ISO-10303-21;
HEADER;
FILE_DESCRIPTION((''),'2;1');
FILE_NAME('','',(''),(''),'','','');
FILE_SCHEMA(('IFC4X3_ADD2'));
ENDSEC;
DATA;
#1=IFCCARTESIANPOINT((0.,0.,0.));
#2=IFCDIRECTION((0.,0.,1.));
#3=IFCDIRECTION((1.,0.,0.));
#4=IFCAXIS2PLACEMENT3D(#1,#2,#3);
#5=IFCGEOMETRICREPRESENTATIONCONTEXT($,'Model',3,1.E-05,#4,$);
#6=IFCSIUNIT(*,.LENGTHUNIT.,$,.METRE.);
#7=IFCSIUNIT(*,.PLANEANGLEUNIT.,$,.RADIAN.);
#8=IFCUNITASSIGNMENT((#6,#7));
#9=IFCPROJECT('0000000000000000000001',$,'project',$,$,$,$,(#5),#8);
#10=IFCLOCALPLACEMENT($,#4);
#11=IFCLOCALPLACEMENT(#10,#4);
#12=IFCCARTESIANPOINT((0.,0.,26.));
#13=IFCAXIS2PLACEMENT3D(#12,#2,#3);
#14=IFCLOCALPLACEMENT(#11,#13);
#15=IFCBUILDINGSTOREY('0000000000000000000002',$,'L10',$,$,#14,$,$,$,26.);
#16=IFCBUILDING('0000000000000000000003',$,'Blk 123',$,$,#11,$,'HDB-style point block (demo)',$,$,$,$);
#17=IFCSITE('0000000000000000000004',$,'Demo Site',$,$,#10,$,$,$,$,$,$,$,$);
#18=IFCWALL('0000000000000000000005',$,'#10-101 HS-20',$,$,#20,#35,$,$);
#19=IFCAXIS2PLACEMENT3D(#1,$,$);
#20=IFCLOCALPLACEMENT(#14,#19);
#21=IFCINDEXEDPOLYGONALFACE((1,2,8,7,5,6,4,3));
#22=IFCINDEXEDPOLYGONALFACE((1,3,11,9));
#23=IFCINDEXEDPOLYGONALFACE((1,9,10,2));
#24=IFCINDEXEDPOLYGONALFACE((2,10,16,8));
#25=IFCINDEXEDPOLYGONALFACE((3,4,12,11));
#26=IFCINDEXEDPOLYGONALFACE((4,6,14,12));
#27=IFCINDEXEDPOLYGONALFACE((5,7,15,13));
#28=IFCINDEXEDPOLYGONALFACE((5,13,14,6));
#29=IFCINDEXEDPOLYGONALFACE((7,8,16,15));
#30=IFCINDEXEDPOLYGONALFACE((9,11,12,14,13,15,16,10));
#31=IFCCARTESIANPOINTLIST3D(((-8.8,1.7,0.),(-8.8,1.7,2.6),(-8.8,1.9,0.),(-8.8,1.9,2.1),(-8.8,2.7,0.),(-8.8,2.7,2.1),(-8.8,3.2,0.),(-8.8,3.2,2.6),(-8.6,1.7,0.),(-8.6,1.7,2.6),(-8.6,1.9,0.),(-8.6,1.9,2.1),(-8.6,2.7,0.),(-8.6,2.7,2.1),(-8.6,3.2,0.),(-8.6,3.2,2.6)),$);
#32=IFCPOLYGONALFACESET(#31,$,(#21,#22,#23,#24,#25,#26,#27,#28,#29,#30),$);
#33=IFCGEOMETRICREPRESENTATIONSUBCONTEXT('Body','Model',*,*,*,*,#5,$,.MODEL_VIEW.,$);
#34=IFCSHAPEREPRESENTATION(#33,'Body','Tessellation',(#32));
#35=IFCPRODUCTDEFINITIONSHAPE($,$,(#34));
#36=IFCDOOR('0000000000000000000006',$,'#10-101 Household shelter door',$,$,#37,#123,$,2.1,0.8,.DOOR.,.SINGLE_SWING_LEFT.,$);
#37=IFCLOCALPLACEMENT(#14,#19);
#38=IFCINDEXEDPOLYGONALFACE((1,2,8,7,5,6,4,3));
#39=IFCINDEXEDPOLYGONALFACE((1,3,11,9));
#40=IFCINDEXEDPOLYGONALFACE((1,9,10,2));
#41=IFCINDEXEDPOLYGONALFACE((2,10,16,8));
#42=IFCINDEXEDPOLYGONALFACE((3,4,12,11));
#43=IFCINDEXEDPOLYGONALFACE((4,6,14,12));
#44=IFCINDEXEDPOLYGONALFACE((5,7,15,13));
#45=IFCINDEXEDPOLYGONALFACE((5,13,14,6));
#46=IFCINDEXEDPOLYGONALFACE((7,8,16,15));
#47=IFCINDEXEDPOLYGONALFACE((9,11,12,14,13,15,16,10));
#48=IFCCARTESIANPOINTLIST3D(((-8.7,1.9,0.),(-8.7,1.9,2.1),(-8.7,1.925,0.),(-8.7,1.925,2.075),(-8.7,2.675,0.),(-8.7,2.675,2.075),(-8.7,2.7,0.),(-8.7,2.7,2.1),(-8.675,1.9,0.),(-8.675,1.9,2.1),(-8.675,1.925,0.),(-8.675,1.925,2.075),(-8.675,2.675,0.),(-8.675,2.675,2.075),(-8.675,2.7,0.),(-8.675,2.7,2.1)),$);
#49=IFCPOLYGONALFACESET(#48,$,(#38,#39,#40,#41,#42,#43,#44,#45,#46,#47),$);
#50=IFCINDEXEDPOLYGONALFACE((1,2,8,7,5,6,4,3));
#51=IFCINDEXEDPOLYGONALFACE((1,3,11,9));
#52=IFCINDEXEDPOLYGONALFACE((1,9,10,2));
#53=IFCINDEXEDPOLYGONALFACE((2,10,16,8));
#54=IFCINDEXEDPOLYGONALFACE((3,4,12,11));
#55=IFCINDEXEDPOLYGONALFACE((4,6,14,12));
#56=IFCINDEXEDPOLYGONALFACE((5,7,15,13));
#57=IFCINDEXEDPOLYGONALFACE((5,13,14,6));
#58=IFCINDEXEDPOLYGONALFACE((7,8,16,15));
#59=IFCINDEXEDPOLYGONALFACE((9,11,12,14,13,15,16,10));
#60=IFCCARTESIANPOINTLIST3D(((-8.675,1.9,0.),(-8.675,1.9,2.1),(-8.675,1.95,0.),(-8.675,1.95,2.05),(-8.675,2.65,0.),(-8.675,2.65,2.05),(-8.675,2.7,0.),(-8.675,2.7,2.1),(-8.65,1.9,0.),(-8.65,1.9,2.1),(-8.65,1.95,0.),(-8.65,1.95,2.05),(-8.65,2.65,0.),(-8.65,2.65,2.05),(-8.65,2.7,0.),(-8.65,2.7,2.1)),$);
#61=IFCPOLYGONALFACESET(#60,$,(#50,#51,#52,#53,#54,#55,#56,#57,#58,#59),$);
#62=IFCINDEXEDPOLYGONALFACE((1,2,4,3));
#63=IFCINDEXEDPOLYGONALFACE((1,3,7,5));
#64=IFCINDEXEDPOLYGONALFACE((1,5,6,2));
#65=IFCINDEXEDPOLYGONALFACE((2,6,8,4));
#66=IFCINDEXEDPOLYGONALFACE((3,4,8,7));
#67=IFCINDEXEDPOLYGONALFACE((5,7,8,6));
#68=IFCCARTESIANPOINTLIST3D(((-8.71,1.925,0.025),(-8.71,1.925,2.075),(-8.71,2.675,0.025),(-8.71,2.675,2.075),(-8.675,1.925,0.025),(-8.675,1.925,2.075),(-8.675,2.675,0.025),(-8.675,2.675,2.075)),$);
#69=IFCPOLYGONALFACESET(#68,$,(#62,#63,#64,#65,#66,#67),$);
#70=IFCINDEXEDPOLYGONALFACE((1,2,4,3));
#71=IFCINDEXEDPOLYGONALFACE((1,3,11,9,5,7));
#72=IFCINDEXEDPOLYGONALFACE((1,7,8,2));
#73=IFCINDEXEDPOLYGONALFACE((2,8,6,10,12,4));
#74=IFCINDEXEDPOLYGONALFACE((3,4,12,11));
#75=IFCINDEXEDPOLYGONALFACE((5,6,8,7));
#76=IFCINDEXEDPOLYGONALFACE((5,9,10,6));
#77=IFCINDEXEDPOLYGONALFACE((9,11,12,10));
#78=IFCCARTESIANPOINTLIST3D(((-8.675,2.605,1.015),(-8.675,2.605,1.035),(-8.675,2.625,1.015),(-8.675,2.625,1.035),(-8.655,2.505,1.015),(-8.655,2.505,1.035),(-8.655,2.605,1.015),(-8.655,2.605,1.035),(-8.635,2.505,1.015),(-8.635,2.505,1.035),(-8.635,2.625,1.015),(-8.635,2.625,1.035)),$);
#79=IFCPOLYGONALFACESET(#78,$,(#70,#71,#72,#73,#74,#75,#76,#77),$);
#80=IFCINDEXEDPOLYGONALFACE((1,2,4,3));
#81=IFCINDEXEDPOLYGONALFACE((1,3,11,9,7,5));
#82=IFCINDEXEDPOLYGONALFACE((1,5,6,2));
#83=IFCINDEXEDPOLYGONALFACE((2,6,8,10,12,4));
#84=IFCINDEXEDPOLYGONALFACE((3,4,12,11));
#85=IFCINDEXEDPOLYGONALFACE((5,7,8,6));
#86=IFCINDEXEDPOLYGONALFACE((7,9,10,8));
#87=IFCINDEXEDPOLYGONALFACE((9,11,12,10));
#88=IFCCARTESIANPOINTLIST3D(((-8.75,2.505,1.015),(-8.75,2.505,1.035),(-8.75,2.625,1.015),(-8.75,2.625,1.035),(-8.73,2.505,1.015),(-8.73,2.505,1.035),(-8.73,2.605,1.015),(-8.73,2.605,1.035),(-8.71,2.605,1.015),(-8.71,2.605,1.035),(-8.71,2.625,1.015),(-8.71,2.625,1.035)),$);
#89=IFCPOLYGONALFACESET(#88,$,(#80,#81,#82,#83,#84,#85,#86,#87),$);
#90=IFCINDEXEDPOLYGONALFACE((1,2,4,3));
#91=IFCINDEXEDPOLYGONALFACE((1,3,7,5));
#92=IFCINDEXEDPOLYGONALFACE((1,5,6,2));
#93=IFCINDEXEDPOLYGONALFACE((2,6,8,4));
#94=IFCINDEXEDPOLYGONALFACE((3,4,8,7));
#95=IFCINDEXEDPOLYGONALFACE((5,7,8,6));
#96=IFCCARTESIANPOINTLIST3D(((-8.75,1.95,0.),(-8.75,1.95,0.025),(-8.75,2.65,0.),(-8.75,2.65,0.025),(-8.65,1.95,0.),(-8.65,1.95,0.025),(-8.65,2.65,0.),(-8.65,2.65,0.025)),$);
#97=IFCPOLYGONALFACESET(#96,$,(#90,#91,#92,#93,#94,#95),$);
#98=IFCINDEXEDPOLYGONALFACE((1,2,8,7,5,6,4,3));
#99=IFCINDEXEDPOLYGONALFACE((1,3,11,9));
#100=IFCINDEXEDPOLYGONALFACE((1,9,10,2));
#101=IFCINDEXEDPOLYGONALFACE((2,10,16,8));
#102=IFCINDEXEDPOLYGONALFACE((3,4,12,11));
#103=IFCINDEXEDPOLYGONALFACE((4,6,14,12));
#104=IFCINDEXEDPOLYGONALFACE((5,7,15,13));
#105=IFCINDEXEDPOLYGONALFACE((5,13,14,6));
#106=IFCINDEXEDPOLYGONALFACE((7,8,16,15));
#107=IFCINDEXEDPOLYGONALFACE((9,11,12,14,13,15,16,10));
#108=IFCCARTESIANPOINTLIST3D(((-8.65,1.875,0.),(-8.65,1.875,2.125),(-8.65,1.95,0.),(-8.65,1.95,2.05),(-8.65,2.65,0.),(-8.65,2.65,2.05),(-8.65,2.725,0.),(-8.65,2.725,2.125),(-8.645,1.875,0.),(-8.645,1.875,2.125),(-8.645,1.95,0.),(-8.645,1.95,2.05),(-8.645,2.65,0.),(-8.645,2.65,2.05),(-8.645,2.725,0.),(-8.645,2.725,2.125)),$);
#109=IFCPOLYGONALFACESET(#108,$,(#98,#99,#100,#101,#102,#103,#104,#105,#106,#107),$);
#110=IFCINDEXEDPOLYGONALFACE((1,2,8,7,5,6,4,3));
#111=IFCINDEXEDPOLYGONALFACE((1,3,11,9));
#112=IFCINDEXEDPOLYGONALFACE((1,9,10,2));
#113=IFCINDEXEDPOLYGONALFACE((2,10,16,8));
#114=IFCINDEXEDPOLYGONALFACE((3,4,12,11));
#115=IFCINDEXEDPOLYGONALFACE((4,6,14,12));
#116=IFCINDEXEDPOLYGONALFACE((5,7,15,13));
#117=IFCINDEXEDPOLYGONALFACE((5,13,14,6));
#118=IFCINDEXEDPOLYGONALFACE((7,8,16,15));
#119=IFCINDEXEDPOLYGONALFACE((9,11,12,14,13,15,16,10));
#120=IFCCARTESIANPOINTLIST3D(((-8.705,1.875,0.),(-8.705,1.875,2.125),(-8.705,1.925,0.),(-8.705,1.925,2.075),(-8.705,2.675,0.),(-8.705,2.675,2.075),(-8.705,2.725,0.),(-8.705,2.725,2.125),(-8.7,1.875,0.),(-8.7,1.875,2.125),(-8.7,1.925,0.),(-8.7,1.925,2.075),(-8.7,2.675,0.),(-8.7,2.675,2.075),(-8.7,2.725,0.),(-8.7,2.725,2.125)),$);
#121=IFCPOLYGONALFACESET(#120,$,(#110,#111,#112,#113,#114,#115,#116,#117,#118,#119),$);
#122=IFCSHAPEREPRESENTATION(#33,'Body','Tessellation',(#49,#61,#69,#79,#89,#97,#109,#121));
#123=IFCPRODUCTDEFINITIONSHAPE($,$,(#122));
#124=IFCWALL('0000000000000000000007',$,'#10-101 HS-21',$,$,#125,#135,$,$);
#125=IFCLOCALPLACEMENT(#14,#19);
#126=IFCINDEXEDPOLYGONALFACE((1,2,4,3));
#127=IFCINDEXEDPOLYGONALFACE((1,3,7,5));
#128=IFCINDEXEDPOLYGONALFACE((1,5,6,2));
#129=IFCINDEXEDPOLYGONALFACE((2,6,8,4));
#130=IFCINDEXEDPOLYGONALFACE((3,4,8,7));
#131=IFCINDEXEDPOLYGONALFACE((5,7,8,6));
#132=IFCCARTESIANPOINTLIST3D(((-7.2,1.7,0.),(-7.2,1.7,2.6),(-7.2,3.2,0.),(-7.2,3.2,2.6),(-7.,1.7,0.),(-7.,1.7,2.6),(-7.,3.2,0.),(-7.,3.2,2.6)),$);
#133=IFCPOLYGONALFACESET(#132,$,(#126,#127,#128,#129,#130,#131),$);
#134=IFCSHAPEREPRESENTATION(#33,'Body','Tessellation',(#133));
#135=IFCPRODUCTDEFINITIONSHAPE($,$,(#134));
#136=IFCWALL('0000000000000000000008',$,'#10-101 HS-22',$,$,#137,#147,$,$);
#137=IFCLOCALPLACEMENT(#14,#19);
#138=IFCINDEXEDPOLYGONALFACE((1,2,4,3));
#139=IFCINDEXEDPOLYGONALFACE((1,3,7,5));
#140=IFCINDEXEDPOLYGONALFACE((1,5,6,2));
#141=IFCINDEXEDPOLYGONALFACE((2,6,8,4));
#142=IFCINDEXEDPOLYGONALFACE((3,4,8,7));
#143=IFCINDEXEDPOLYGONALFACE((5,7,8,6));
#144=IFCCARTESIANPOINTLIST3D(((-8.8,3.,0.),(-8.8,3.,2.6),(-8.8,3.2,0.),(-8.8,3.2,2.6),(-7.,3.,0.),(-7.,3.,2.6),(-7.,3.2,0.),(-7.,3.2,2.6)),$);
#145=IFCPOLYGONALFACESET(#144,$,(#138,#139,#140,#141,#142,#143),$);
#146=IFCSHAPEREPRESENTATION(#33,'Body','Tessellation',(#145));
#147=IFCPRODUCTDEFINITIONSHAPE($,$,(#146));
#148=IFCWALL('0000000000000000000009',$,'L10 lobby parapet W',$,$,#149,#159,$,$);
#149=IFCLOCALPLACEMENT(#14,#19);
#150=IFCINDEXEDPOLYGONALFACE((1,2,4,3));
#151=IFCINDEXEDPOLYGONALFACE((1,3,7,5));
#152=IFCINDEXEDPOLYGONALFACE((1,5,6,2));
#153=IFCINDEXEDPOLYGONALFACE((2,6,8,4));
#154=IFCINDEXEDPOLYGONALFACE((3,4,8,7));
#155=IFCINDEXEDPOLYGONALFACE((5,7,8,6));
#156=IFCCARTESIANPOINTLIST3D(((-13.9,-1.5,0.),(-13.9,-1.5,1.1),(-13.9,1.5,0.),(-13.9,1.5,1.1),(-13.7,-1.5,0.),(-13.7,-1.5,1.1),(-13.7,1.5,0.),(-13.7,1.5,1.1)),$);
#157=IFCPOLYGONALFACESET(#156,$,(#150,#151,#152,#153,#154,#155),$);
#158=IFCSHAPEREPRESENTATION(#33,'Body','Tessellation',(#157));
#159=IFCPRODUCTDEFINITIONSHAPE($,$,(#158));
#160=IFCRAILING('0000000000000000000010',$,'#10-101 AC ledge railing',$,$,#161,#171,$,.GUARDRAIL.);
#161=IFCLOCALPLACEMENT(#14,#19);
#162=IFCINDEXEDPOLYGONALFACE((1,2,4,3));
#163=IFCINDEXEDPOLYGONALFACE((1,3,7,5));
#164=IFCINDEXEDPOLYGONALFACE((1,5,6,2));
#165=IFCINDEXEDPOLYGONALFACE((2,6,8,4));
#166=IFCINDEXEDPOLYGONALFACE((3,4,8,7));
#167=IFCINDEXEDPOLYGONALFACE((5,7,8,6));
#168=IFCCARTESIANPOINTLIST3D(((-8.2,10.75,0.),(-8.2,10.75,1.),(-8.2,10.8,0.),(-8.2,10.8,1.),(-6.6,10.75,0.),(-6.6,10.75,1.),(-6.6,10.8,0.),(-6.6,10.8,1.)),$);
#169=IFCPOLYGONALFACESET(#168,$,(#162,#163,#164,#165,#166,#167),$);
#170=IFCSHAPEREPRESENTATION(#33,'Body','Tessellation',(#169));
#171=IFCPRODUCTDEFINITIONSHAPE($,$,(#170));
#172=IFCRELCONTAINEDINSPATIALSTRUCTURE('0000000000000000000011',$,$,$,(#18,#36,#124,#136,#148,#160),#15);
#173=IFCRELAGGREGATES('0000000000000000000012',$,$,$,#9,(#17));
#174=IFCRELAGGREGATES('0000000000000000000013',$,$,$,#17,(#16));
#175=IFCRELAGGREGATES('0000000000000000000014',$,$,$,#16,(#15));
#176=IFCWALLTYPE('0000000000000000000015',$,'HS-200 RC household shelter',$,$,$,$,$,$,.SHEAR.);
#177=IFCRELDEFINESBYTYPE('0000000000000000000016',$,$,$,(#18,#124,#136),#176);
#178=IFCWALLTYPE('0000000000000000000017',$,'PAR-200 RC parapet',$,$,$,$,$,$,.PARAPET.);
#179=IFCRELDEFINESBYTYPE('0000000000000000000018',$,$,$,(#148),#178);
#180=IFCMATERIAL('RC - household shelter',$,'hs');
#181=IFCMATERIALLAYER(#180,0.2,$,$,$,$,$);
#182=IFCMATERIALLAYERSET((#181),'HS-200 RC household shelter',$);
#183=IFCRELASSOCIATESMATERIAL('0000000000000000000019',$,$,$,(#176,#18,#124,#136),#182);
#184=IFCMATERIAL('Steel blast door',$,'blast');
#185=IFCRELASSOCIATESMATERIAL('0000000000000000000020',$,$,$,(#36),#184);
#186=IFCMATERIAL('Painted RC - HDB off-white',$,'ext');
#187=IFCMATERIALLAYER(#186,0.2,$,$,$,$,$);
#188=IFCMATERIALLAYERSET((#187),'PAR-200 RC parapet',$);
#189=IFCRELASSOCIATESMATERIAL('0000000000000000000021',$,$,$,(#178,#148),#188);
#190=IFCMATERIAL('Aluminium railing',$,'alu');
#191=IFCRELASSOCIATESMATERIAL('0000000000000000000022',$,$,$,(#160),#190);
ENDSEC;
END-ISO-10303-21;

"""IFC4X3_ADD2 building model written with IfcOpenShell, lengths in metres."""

from ifc_helpers import new_model, si_unit, frame, origin, origin_with_axes, place, context, subcontext, project, spatial, polyline, line, indexed_curve, outline, extrude, material, layer, layer_set, layer_usage, type_object, element, fill, save


model = new_model("IFC4X3_ADD2")

# Units and contexts
model_context = context("Model", 3, precision=1e-05, world=origin_with_axes())
body_context = subcontext(model_context, "Body", "Model", "MODEL_VIEW")
ifc_project = project(units=[si_unit("LENGTHUNIT", "METRE"), si_unit("PLANEANGLEUNIT", "RADIAN")], contexts=[model_context])

# Site, building, storey
site_placement = place(None, origin_with_axes())
site = spatial("IfcSite", under=ifc_project, at=site_placement, Name="Demo Site")
building_placement = place(site_placement, origin_with_axes())
building = spatial("IfcBuilding", under=site, at=building_placement, Name="Blk 123", LongName="HDB-style point block (demo)")
storey_placement = place(building_placement, frame((0.0, 0.0, 26.0), z_axis=(0.0, 0.0, 1.0), x_axis=(1.0, 0.0, 0.0)))
storey = spatial("IfcBuildingStorey", under=building, at=storey_placement, Name="L10", Elevation=26.0)

# Shared definitions
ifc_material_1 = material(Name="Painted RC - HDB off-white", Category="ext")

# Wall, opening, door
ifc_material_2 = material(Name="RC - household shelter", Category="hs")
ifc_layer_1 = layer(ifc_material_2, 0.2)
ifc_layer_set_1 = layer_set([ifc_layer_1], Name="HS-200 RC household shelter")
ifc_layer_usage_1 = layer_usage(ifc_layer_set_1, "AXIS2", "POSITIVE", -0.1)
wall_type_1 = type_object("IfcWallType", Name="HS-200 RC household shelter", PredefinedType="SHEAR", material=ifc_layer_set_1)
wall_1_placement = place(storey_placement, frame((-8.7, 1.7, 0.0), z_axis=(0.0, 0.0, 1.0), x_axis=(0.0, 1.0, 0.0)))
wall_1 = element("IfcWall", 1, at=wall_1_placement, inside=storey, type_object=wall_type_1, material=ifc_layer_usage_1, Name="#10-101 HS-20", context=body_context, shape_type="SweptSolid", body=[
    extrude(outline(indexed_curve([(0.0, 0.0), (0.0, 0.2), (1.5, 0.2), (1.5, 0.0), (0.0, 0.0)], self_intersect=False)), frame((0.0, -0.1, 0.0), z_axis=(0.0, 0.0, 1.0), x_axis=(1.0, 0.0, 0.0)), (0.0, 0.0, 1.0), 2.6),
])
opening_1_placement = place(wall_1_placement, frame((0.2, -0.2, 0.0), z_axis=(0.0, 0.0, 1.0), x_axis=(1.0, 0.0, 0.0)))
opening_1 = element("IfcOpeningElement", 2, at=opening_1_placement, cuts=wall_1, context=body_context, shape_type="SweptSolid", body=[
    extrude(outline(indexed_curve([(0.0, 0.0), (0.0, 0.4), (0.8, 0.4), (0.8, 0.0), (0.0, 0.0)], self_intersect=False)), origin_with_axes(), (0.0, 0.0, 1.0), 2.1),
])
ifc_material_3 = material(Name="Steel blast door", Category="blast")
door_1_placement = place(opening_1_placement, frame((0.0, 0.15, 0.0), z_axis=(0.0, 0.0, 1.0), x_axis=(1.0, 0.0, 0.0)))
door_1 = element("IfcDoor", 3, at=door_1_placement, inside=storey, material=ifc_material_3, Name="#10-101 Household shelter door", OperationType="SINGLE_SWING_LEFT", OverallHeight=2.1, OverallWidth=0.8, PredefinedType="DOOR", context=body_context, shape_type="SweptSolid", body=[
    extrude(outline(indexed_curve([(0.0, 0.0), (0.0, 2.1), (0.8, 2.1), (0.8, 0.0), (0.775, 0.0), (0.775, 2.075), (0.025, 2.075), (0.025, 0.0)], segments=[line(1, 2, 3, 4, 5, 6, 7, 8, 1)])), frame((0.0, 0.025, 0.0), z_axis=(0.0, -1.0, 0.0), x_axis=(1.0, 0.0, 0.0)), (0.0, 0.0, -1.0), 0.025),
    extrude(outline(indexed_curve([(0.0, 0.0), (0.0, 2.1), (0.8, 2.1), (0.8, 0.0), (0.75, 0.0), (0.75, 2.05), (0.05, 2.05), (0.05, 0.0)], segments=[line(1, 2, 3, 4, 5, 6, 7, 8, 1)])), frame((0.0, 0.0, 0.0), z_axis=(0.0, -1.0, 0.0), x_axis=(1.0, 0.0, 0.0)), (0.0, 0.0, -1.0), 0.025),
    extrude(outline(indexed_curve([(0.0, 0.0), (0.75, 0.0), (0.75, 0.035), (0.0, 0.035)], segments=[line(1, 2, 3, 4, 1)])), frame((0.025, 0.025, 0.025), z_axis=(0.0, 0.0, 1.0), x_axis=(1.0, 0.0, 0.0)), (0.0, 0.0, 1.0), 2.05),
    extrude(outline(indexed_curve([(0.0, 0.0), (0.0, -0.04), (-0.12, -0.04), (-0.12, -0.02), (-0.02, -0.02), (-0.02, 0.0)], segments=[line(1, 2, 3, 4, 5, 6, 1)])), frame((0.725, 0.025, 1.015), z_axis=(0.0, 0.0, 1.0), x_axis=(1.0, 0.0, 0.0)), (0.0, 0.0, 1.0), 0.02),
    extrude(outline(indexed_curve([(0.0, 0.0), (0.0, 0.04), (-0.12, 0.04), (-0.12, 0.02), (-0.02, 0.02), (-0.02, 0.0)], segments=[line(1, 2, 3, 4, 5, 6, 1)])), frame((0.725, 0.06, 1.015), z_axis=(0.0, 0.0, 1.0), x_axis=(1.0, 0.0, 0.0)), (0.0, 0.0, 1.0), 0.02),
    extrude(outline(indexed_curve([(0.0, 0.0), (0.7, 0.0), (0.7, 0.1), (0.0, 0.1)], segments=[line(1, 2, 3, 4, 1)])), frame((0.05, 0.0, 0.0), z_axis=(0.0, 0.0, 1.0), x_axis=(1.0, 0.0, 0.0)), (0.0, 0.0, 1.0), 0.025),
    extrude(outline(indexed_curve([(0.0, 0.0), (0.0, 2.125), (0.85, 2.125), (0.85, 0.0), (0.775, 0.0), (0.775, 2.05), (0.075, 2.05), (0.075, 0.0)], segments=[line(1, 2, 3, 4, 5, 6, 7, 8, 1)])), frame((-0.025, -0.005, 0.0), z_axis=(0.0, -1.0, 0.0), x_axis=(1.0, 0.0, 0.0)), (0.0, 0.0, -1.0), 0.005),
    extrude(outline(indexed_curve([(0.0, 0.0), (0.0, 2.125), (0.85, 2.125), (0.85, 0.0), (0.8, 0.0), (0.8, 2.075), (0.05, 2.075), (0.05, 0.0)], segments=[line(1, 2, 3, 4, 5, 6, 7, 8, 1)])), frame((-0.025, 0.05, 0.0), z_axis=(0.0, -1.0, 0.0), x_axis=(1.0, 0.0, 0.0)), (0.0, 0.0, -1.0), 0.005),
])
fill(opening_1, door_1)

# Walls
wall_2_placement = place(storey_placement, frame((-7.1, 1.7, 0.0), z_axis=(0.0, 0.0, 1.0), x_axis=(0.0, 1.0, 0.0)))
element("IfcWall", 4, at=wall_2_placement, inside=storey, type_object=wall_type_1, material=ifc_layer_usage_1, Name="#10-101 HS-21", context=body_context, shape_type="SweptSolid", body=[
    extrude(outline(indexed_curve([(0.0, 0.0), (0.0, 0.2), (1.5, 0.2), (1.5, 0.0), (0.0, 0.0)], self_intersect=False)), frame((0.0, -0.1, 0.0), z_axis=(0.0, 0.0, 1.0), x_axis=(1.0, 0.0, 0.0)), (0.0, 0.0, 1.0), 2.6),
])
wall_3_placement = place(storey_placement, frame((-7.0, 3.1, 0.0), z_axis=(0.0, 0.0, 1.0), x_axis=(-1.0, 0.0, 0.0)))
element("IfcWall", 5, at=wall_3_placement, inside=storey, type_object=wall_type_1, material=ifc_layer_usage_1, Name="#10-101 HS-22", context=body_context, shape_type="SweptSolid", body=[
    extrude(outline(indexed_curve([(0.0, 0.0), (0.0, 0.2), (1.8, 0.2), (1.8, 0.0), (0.0, 0.0)], self_intersect=False)), frame((0.0, -0.1, 0.0), z_axis=(0.0, 0.0, 1.0), x_axis=(1.0, 0.0, 0.0)), (0.0, 0.0, 1.0), 2.6),
])
ifc_layer_2 = layer(ifc_material_1, 0.2)
ifc_layer_set_2 = layer_set([ifc_layer_2], Name="PAR-200 RC parapet")
ifc_layer_usage_2 = layer_usage(ifc_layer_set_2, "AXIS2", "POSITIVE", 0.0)
wall_type_2 = type_object("IfcWallType", Name="PAR-200 RC parapet", PredefinedType="PARAPET", material=ifc_layer_set_2)
wall_4_placement = place(storey_placement, frame((-13.9, 1.5, 0.0), z_axis=(0.0, 0.0, 1.0), x_axis=(0.0, -1.0, 0.0)))
element("IfcWall", 6, at=wall_4_placement, inside=storey, type_object=wall_type_2, material=ifc_layer_usage_2, Name="L10 lobby parapet W", context=body_context, shape_type="SweptSolid", body=[
    extrude(outline(indexed_curve([(0.0, 0.0), (0.0, 0.2), (3.0, 0.2), (3.0, 0.0), (0.0, 0.0)], self_intersect=False)), origin_with_axes(), (0.0, 0.0, 1.0), 1.1),
])

# Railing
ifc_material_4 = material(Name="Aluminium railing", Category="alu")
railing_placement = place(storey_placement, frame((-7.4, 10.775, 0.0), z_axis=(0.0, 0.0, 1.0), x_axis=(1.0, 0.0, 0.0)))
element("IfcRailing", 7, at=railing_placement, inside=storey, material=ifc_material_4, Name="#10-101 AC ledge railing", PredefinedType="GUARDRAIL", context=body_context, shape_type="SweptSolid", body=[
    extrude(outline(polyline([(-0.8, -0.025), (0.8, -0.025), (0.8, 0.025), (-0.8, 0.025), (-0.8, -0.025)])), origin(), (0.0, 0.0, 1.0), 1.0),
])

save(model, "model.ifc")
